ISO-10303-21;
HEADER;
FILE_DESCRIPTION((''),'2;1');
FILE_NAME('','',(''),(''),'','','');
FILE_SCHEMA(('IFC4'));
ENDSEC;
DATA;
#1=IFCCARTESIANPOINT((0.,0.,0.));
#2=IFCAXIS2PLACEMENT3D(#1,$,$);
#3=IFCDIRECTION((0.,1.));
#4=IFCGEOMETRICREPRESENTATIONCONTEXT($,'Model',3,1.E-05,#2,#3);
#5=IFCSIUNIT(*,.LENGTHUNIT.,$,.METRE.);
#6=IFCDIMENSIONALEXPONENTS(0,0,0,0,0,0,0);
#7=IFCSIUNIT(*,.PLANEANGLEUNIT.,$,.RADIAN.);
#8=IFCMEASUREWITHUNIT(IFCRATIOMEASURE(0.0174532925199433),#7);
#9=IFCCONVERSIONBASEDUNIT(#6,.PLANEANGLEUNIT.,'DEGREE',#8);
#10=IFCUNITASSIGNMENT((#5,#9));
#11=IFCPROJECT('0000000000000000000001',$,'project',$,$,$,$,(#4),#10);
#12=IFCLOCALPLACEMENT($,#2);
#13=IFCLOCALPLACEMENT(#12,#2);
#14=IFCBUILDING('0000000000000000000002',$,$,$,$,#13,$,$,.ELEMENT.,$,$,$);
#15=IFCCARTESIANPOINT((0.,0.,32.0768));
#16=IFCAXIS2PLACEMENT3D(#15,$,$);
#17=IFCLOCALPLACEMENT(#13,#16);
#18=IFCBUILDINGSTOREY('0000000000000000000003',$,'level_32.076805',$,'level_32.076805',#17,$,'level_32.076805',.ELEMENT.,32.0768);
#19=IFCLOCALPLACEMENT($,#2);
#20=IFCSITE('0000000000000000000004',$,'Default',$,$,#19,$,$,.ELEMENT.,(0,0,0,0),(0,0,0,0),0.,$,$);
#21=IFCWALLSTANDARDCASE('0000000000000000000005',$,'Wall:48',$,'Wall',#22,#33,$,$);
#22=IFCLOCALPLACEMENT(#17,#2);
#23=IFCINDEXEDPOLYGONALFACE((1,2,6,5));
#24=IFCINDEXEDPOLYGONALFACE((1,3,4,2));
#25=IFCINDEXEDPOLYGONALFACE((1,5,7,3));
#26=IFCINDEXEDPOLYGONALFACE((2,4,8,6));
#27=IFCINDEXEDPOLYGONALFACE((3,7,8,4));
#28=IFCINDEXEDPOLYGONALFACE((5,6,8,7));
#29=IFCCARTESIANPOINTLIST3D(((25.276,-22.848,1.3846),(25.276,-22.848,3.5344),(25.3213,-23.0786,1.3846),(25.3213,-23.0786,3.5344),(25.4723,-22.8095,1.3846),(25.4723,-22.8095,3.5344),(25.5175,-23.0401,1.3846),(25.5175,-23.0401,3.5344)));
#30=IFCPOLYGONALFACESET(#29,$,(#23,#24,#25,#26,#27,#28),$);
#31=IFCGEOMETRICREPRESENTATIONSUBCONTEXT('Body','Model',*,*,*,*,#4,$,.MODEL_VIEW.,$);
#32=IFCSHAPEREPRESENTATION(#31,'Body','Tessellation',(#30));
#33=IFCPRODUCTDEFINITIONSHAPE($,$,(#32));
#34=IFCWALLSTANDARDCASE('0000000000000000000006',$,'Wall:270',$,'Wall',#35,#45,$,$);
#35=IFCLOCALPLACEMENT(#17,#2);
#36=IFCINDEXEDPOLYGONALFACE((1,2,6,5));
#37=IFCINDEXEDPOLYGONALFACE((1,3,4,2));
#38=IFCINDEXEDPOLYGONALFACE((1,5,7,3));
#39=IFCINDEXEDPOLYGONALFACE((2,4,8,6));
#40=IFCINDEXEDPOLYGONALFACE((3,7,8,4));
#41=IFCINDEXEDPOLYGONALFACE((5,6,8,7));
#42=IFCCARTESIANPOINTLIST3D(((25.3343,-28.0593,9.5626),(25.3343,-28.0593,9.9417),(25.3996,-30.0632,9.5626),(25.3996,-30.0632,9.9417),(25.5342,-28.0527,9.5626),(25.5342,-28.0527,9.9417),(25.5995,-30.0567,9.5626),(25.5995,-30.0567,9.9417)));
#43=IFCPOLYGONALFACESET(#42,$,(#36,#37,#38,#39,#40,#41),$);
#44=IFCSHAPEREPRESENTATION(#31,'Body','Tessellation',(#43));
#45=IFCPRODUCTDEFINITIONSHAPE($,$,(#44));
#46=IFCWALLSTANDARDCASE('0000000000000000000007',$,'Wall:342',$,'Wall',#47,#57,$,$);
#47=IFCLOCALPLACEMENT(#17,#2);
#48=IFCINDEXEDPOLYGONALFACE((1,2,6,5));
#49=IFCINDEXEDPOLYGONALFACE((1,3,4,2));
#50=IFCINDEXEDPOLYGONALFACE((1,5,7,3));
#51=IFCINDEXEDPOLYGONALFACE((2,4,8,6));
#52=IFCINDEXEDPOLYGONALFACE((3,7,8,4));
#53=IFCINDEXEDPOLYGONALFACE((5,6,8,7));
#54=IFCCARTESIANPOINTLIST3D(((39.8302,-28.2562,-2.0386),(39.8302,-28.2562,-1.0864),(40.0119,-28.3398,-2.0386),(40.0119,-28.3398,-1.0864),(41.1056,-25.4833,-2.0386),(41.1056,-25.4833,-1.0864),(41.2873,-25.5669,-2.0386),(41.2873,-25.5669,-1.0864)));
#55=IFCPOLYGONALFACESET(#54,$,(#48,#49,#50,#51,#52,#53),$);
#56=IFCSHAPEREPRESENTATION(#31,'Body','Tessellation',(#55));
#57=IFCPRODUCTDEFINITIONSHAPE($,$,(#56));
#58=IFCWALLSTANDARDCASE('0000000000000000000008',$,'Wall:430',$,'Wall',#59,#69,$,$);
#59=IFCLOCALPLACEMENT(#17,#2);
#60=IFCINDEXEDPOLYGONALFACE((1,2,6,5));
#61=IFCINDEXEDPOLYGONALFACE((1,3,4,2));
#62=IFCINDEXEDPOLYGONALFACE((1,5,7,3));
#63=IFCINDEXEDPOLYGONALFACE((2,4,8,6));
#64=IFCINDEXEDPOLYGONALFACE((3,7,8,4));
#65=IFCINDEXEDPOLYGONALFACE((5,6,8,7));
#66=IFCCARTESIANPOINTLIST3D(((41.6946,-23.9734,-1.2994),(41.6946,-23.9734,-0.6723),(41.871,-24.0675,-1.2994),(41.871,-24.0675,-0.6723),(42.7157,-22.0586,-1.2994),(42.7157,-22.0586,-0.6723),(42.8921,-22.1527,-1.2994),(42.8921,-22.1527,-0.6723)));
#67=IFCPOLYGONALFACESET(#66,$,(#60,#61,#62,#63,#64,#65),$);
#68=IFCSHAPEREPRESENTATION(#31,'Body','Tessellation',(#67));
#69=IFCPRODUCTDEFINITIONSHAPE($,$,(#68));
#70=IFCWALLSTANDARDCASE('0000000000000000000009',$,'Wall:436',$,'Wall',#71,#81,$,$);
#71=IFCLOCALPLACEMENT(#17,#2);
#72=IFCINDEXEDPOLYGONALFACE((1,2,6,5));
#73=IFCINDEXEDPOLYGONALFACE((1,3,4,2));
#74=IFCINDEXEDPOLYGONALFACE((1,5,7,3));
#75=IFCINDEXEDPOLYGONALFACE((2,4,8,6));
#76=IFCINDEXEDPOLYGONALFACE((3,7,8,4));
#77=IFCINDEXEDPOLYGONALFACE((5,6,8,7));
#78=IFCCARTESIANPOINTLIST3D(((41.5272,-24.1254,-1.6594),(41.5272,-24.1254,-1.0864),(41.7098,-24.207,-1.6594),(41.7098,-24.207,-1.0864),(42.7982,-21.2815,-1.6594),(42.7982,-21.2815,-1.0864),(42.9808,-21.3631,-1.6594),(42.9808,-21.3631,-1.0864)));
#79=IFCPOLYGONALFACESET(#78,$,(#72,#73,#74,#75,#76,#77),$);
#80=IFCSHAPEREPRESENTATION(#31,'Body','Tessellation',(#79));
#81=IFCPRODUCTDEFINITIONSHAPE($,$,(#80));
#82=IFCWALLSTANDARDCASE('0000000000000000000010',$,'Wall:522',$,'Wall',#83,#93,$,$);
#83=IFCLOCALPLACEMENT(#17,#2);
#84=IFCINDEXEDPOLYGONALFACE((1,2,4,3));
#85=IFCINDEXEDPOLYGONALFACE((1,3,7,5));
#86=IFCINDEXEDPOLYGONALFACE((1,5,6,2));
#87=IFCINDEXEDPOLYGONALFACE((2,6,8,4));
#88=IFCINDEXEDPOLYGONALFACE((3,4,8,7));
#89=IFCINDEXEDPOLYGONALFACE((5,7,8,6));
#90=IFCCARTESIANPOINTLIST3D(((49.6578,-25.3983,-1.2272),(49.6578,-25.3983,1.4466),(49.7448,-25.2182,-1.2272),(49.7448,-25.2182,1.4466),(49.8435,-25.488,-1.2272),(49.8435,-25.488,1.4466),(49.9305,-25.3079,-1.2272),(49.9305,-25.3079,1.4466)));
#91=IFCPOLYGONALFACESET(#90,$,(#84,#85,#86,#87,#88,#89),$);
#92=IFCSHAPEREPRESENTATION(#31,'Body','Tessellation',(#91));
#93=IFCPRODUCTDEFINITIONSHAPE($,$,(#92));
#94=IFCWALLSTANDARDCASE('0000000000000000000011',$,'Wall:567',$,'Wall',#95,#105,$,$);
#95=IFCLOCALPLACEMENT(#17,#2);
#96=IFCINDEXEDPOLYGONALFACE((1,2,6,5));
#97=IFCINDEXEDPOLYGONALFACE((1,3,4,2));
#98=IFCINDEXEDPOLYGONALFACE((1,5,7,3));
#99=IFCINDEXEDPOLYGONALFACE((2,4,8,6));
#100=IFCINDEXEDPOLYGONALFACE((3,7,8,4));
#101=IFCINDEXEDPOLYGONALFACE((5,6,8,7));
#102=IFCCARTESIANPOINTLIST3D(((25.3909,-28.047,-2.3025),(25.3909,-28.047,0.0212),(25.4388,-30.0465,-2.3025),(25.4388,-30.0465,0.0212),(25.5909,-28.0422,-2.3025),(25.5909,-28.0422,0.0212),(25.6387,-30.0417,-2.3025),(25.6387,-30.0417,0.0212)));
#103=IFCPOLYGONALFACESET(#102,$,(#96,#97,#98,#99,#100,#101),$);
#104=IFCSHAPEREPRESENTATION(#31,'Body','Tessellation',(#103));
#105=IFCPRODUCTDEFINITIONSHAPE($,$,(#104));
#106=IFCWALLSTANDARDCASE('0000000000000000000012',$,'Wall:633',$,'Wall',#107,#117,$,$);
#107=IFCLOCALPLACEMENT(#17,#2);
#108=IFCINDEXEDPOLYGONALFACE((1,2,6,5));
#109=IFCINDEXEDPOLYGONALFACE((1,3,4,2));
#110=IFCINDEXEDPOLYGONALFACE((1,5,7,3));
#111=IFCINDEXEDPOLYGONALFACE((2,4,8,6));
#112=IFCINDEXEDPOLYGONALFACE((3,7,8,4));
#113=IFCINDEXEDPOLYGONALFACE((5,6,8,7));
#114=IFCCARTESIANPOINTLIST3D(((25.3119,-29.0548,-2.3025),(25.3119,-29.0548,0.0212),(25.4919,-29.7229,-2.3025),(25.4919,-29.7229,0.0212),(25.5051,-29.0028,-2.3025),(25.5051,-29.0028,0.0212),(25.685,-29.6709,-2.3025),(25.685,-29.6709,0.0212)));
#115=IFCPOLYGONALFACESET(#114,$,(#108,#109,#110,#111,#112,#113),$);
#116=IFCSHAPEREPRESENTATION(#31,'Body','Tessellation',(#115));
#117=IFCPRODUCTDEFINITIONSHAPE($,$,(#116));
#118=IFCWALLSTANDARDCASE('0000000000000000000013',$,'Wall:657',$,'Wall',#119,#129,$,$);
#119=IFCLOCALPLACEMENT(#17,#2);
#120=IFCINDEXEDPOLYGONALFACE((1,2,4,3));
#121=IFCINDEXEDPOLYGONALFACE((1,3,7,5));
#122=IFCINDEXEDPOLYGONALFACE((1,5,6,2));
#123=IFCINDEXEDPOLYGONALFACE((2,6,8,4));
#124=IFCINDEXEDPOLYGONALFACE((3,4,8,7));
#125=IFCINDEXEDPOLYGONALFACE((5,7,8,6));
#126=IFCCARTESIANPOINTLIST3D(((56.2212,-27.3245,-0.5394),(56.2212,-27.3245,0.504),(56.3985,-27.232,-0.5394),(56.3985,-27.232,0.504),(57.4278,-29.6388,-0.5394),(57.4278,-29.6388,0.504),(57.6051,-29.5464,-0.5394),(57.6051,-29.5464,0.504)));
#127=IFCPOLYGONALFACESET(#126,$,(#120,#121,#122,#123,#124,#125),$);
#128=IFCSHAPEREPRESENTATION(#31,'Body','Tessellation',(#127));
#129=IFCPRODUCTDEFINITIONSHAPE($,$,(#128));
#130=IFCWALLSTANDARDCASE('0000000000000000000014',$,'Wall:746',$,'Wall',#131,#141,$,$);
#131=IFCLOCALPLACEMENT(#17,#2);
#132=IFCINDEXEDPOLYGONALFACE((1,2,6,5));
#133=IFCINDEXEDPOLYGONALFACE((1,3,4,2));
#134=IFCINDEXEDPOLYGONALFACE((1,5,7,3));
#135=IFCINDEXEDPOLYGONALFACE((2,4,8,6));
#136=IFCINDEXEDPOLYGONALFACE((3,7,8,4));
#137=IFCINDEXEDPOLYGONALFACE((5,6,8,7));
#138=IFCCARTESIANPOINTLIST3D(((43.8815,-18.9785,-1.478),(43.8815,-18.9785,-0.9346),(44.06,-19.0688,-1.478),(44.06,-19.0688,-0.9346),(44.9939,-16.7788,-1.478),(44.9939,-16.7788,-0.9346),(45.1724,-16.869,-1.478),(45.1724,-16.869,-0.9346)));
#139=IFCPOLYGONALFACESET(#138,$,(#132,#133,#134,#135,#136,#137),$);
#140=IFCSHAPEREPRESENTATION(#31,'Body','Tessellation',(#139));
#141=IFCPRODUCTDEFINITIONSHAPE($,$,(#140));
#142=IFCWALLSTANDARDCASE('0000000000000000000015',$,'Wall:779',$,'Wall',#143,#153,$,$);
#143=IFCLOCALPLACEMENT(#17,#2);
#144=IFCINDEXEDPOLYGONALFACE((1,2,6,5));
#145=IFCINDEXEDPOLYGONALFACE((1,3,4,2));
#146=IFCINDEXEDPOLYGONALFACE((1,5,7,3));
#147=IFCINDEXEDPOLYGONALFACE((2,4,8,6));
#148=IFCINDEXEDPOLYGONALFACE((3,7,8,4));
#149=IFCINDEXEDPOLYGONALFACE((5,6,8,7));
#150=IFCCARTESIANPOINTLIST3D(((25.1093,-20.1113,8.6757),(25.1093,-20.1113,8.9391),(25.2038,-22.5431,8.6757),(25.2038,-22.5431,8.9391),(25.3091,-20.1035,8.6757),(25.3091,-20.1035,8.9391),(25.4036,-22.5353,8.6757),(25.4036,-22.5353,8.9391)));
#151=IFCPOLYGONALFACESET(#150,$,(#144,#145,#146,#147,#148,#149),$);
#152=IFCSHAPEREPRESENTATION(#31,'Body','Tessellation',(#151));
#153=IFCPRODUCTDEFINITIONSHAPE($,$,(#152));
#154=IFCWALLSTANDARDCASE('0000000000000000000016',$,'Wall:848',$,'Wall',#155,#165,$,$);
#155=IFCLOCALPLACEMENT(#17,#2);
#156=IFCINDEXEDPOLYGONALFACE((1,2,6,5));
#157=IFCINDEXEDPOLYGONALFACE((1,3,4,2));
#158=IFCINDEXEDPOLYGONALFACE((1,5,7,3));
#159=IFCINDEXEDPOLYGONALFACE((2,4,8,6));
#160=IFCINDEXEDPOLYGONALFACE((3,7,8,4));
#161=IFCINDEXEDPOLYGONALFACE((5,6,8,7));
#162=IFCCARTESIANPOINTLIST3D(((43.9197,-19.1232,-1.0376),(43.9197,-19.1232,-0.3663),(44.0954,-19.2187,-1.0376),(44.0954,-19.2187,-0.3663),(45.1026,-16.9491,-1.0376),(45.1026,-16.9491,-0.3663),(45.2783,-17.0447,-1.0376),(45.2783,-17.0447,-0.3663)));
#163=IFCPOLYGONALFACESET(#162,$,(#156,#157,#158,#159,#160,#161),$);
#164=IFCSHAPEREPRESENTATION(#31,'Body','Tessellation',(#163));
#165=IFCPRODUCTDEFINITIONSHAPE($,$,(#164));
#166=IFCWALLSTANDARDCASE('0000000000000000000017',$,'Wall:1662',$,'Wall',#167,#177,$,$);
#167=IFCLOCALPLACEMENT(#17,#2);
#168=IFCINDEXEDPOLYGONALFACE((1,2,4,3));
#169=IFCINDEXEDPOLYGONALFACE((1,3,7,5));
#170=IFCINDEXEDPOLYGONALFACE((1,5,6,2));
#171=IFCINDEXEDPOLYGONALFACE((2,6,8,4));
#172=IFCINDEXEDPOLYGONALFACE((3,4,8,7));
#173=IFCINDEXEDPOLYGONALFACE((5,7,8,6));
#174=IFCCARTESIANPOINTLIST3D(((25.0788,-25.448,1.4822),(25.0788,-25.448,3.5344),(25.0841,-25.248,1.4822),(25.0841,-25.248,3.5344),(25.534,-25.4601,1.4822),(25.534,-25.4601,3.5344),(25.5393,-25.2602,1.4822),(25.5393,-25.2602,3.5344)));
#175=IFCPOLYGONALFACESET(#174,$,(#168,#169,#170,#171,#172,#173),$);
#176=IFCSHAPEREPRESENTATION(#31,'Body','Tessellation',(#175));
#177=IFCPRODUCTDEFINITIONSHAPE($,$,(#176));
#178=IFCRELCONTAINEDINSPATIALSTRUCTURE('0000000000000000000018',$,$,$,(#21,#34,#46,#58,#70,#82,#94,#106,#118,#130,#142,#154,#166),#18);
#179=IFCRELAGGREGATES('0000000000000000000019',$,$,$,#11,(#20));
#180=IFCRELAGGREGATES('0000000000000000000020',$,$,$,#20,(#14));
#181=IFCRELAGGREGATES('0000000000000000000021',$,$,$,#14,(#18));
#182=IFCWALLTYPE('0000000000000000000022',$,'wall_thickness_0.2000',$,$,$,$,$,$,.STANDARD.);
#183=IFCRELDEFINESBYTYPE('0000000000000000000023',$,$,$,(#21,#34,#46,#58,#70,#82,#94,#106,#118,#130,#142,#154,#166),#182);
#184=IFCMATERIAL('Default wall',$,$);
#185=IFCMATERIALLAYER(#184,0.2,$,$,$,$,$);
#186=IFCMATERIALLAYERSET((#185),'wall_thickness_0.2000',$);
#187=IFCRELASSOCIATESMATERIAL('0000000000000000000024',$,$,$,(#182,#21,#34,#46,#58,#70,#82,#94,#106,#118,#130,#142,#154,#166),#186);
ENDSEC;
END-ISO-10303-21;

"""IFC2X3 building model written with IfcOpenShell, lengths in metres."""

from ifc_helpers import new_model, entity, si_unit, converted_unit, direction, frame, origin, place, context, subcontext, project, spatial, polyline, outline, extrude, material, layer, layer_set, layer_usage, type_object, element, save


model = new_model("IFC2X3")

# Units and contexts
model_context = context("Model", 3, precision=1e-05, world=origin(), true_north=direction((0.0, 1.0)))
body_context = subcontext(model_context, "Body", "Model", "MODEL_VIEW")
ifc_project = project(units=[si_unit("LENGTHUNIT", "METRE"), converted_unit("PLANEANGLEUNIT", "DEGREE", entity("IfcRatioMeasure", 0.0174532925199433), si_unit("PLANEANGLEUNIT", "RADIAN"), dimensions=[0, 0, 0, 0, 0, 0, 0])], contexts=[model_context])

# Site, building, storey
site_placement = place(None, origin())
site = spatial("IfcSite", under=ifc_project, at=site_placement, Name="Default", CompositionType="ELEMENT", RefLatitude=(0, 0, 0, 0), RefLongitude=(0, 0, 0, 0), RefElevation=0.0)
placement_1 = place(None, origin())
building_placement = place(placement_1, origin())
building = spatial("IfcBuilding", under=site, at=building_placement, CompositionType="ELEMENT")
storey_placement = place(building_placement, frame((0.0, 0.0, 32.0768)))
storey = spatial("IfcBuildingStorey", under=building, at=storey_placement, Name="level_32.076805", ObjectType="level_32.076805", LongName="level_32.076805", CompositionType="ELEMENT", Elevation=32.0768)

# Walls
ifc_material = material(Name="Default wall")
ifc_layer = layer(ifc_material, 0.2)
ifc_layer_set = layer_set([ifc_layer], Name="wall_thickness_0.2000")
ifc_layer_usage = layer_usage(ifc_layer_set, "AXIS2", "POSITIVE", -0.1)
wall_type = type_object("IfcWallType", Name="wall_thickness_0.2000", PredefinedType="STANDARD", material=ifc_layer_set)
placement_2 = place(building_placement, frame((0.0, 0.0, 33.4614)))
wall_1_placement = place(placement_2, frame((25.4194, -23.0593, 0.0), z_axis=(0.0, 0.0, 1.0), x_axis=(-0.192505, 0.981296, 0.0)))
element("IfcWallStandardCase", 1, at=wall_1_placement, inside=storey, type_object=wall_type, material=ifc_layer_usage, Name="Wall:48", ObjectType="Wall", context=body_context, shape_type="SweptSolid", body=[
    extrude(outline(polyline([(0.235, -0.1), (0.235, 0.1), (0.0, 0.1), (0.0, -0.1), (0.235, -0.1)])), origin(), (0.0, 0.0, 1.0), 2.1498),
])
placement_3 = place(building_placement, frame((0.0, 0.0, 41.6394)))
wall_2_placement = place(placement_3, frame((25.4342, -28.056, 0.0), z_axis=(0.0, 0.0, 1.0), x_axis=(0.032586, -0.999469, 0.0)))
element("IfcWallStandardCase", 2, at=wall_2_placement, inside=storey, type_object=wall_type, material=ifc_layer_usage, Name="Wall:270", ObjectType="Wall", context=body_context, shape_type="SweptSolid", body=[
    extrude(outline(polyline([(2.005, -0.1), (2.005, 0.1), (0.0, 0.1), (0.0, -0.1), (2.005, -0.1)])), origin(), (0.0, 0.0, 1.0), 0.379),
])
placement_4 = place(building_placement, frame((0.0, 0.0, 30.0382)))
wall_3_placement = place(placement_4, frame((39.9211, -28.298, 0.0), z_axis=(0.0, 0.0, 1.0), x_axis=(0.417876, 0.908504, 0.0)))
element("IfcWallStandardCase", 3, at=wall_3_placement, inside=storey, type_object=wall_type, material=ifc_layer_usage, Name="Wall:342", ObjectType="Wall", context=body_context, shape_type="SweptSolid", body=[
    extrude(outline(polyline([(3.0522, -0.1), (3.0522, 0.1), (0.0, 0.1), (0.0, -0.1), (3.0522, -0.1)])), origin(), (0.0, 0.0, 1.0), 0.9522),
])
placement_5 = place(building_placement, frame((0.0, 0.0, 30.7774)))
wall_4_placement = place(placement_5, frame((41.7828, -24.0204, 0.0), z_axis=(0.0, 0.0, 1.0), x_axis=(0.470558, 0.882369, 0.0)))
element("IfcWallStandardCase", 4, at=wall_4_placement, inside=storey, type_object=wall_type, material=ifc_layer_usage, Name="Wall:430", ObjectType="Wall", context=body_context, shape_type="SweptSolid", body=[
    extrude(outline(polyline([(2.17, -0.1), (2.17, 0.1), (0.0, 0.1), (0.0, -0.1), (2.17, -0.1)])), origin(), (0.0, 0.0, 1.0), 0.6271),
])
placement_6 = place(building_placement, frame((0.0, 0.0, 30.4174)))
wall_5_placement = place(placement_6, frame((41.6185, -24.1662, 0.0), z_axis=(0.0, 0.0, 1.0), x_axis=(0.408002, 0.912981, 0.0)))
element("IfcWallStandardCase", 5, at=wall_5_placement, inside=storey, type_object=wall_type, material=ifc_layer_usage, Name="Wall:436", ObjectType="Wall", context=body_context, shape_type="SweptSolid", body=[
    extrude(outline(polyline([(3.115, -0.1), (3.115, 0.1), (0.0, 0.1), (0.0, -0.1), (3.115, -0.1)])), origin(), (0.0, 0.0, 1.0), 0.573),
])
placement_7 = place(building_placement, frame((0.0, 0.0, 30.8496)))
wall_6_placement = place(placement_7, frame((49.887, -25.3979, 0.0), z_axis=(0.0, 0.0, 1.0), x_axis=(-0.900432, 0.434996, 0.0)))
element("IfcWallStandardCase", 6, at=wall_6_placement, inside=storey, type_object=wall_type, material=ifc_layer_usage, Name="Wall:522", ObjectType="Wall", context=body_context, shape_type="SweptSolid", body=[
    extrude(outline(polyline([(0.2063, -0.1), (0.2063, 0.1), (0.0, 0.1), (0.0, -0.1), (0.2063, -0.1)])), origin(), (0.0, 0.0, 1.0), 2.6738),
])
placement_8 = place(building_placement, frame((0.0, 0.0, 29.7743)))
wall_7_placement = place(placement_8, frame((25.5388, -30.0441, 0.0), z_axis=(0.0, 0.0, 1.0), x_axis=(-0.023922, 0.999714, 0.0)))
element("IfcWallStandardCase", 7, at=wall_7_placement, inside=storey, type_object=wall_type, material=ifc_layer_usage, Name="Wall:567", ObjectType="Wall", context=body_context, shape_type="SweptSolid", body=[
    extrude(outline(polyline([(2.0, -0.1), (2.0, 0.1), (0.0, 0.1), (0.0, -0.1), (2.0, -0.1)])), origin(), (0.0, 0.0, 1.0), 2.3238),
])
placement_9 = place(building_placement, frame((0.0, 0.0, 29.7743)))
wall_8_placement = place(placement_9, frame((25.4085, -29.0288, 0.0), z_axis=(0.0, 0.0, 1.0), x_axis=(0.260093, -0.965584, 0.0)))
element("IfcWallStandardCase", 8, at=wall_8_placement, inside=storey, type_object=wall_type, material=ifc_layer_usage, Name="Wall:633", ObjectType="Wall", context=body_context, shape_type="SweptSolid", body=[
    extrude(outline(polyline([(0.6919, -0.1), (0.6919, 0.1), (0.0, 0.1), (0.0, -0.1), (0.6919, -0.1)])), origin(), (0.0, 0.0, 1.0), 2.3238),
])
placement_10 = place(building_placement, frame((0.0, 0.0, 31.5374)))
wall_9_placement = place(placement_10, frame((56.3098, -27.2783, 0.0), z_axis=(0.0, 0.0, 1.0), x_axis=(0.462308, -0.88672, 0.0)))
element("IfcWallStandardCase", 9, at=wall_9_placement, inside=storey, type_object=wall_type, material=ifc_layer_usage, Name="Wall:657", ObjectType="Wall", context=body_context, shape_type="SweptSolid", body=[
    extrude(outline(polyline([(2.61, -0.1), (2.61, 0.1), (0.0, 0.1), (0.0, -0.1), (2.61, -0.1)])), origin(), (0.0, 0.0, 1.0), 1.0434),
])
placement_11 = place(building_placement, frame((0.0, 0.0, 30.5988)))
wall_10_placement = place(placement_11, frame((43.9708, -19.0236, 0.0), z_axis=(0.0, 0.0, 1.0), x_axis=(0.451261, 0.892392, 0.0)))
element("IfcWallStandardCase", 10, at=wall_10_placement, inside=storey, type_object=wall_type, material=ifc_layer_usage, Name="Wall:746", ObjectType="Wall", context=body_context, shape_type="SweptSolid", body=[
    extrude(outline(polyline([(2.465, -0.1), (2.465, 0.1), (0.0, 0.1), (0.0, -0.1), (2.465, -0.1)])), origin(), (0.0, 0.0, 1.0), 0.5433),
])
placement_12 = place(building_placement, frame((0.0, 0.0, 40.7525)))
wall_11_placement = place(placement_12, frame((25.2092, -20.1074, 0.0), z_axis=(0.0, 0.0, 1.0), x_axis=(0.038813, -0.999246, 0.0)))
element("IfcWallStandardCase", 11, at=wall_11_placement, inside=storey, type_object=wall_type, material=ifc_layer_usage, Name="Wall:779", ObjectType="Wall", context=body_context, shape_type="SweptSolid", body=[
    extrude(outline(polyline([(2.4336, -0.1), (2.4336, 0.1), (0.0, 0.1), (0.0, -0.1), (2.4336, -0.1)])), origin(), (0.0, 0.0, 1.0), 0.2634),
])
placement_13 = place(building_placement, frame((0.0, 0.0, 31.0392)))
wall_12_placement = place(placement_13, frame((44.0075, -19.1709, 0.0), z_axis=(0.0, 0.0, 1.0), x_axis=(0.477936, 0.878395, 0.0)))
element("IfcWallStandardCase", 12, at=wall_12_placement, inside=storey, type_object=wall_type, material=ifc_layer_usage, Name="Wall:848", ObjectType="Wall", context=body_context, shape_type="SweptSolid", body=[
    extrude(outline(polyline([(2.475, -0.1), (2.475, 0.1), (0.0, 0.1), (0.0, -0.1), (2.475, -0.1)])), origin(), (0.0, 0.0, 1.0), 0.6713),
])
placement_14 = place(building_placement, frame((0.0, 0.0, 33.559)))
wall_13_placement = place(placement_14, frame((25.5366, -25.3601, 0.0), z_axis=(0.0, 0.0, 1.0), x_axis=(-0.999646, 0.02659, 0.0)))
element("IfcWallStandardCase", 13, at=wall_13_placement, inside=storey, type_object=wall_type, material=ifc_layer_usage, Name="Wall:1662", ObjectType="Wall", context=body_context, shape_type="SweptSolid", body=[
    extrude(outline(polyline([(0.4554, -0.1), (0.4554, 0.1), (0.0, 0.1), (0.0, -0.1), (0.4554, -0.1)])), origin(), (0.0, 0.0, 1.0), 2.0522),
])

save(model, "model.ifc")
